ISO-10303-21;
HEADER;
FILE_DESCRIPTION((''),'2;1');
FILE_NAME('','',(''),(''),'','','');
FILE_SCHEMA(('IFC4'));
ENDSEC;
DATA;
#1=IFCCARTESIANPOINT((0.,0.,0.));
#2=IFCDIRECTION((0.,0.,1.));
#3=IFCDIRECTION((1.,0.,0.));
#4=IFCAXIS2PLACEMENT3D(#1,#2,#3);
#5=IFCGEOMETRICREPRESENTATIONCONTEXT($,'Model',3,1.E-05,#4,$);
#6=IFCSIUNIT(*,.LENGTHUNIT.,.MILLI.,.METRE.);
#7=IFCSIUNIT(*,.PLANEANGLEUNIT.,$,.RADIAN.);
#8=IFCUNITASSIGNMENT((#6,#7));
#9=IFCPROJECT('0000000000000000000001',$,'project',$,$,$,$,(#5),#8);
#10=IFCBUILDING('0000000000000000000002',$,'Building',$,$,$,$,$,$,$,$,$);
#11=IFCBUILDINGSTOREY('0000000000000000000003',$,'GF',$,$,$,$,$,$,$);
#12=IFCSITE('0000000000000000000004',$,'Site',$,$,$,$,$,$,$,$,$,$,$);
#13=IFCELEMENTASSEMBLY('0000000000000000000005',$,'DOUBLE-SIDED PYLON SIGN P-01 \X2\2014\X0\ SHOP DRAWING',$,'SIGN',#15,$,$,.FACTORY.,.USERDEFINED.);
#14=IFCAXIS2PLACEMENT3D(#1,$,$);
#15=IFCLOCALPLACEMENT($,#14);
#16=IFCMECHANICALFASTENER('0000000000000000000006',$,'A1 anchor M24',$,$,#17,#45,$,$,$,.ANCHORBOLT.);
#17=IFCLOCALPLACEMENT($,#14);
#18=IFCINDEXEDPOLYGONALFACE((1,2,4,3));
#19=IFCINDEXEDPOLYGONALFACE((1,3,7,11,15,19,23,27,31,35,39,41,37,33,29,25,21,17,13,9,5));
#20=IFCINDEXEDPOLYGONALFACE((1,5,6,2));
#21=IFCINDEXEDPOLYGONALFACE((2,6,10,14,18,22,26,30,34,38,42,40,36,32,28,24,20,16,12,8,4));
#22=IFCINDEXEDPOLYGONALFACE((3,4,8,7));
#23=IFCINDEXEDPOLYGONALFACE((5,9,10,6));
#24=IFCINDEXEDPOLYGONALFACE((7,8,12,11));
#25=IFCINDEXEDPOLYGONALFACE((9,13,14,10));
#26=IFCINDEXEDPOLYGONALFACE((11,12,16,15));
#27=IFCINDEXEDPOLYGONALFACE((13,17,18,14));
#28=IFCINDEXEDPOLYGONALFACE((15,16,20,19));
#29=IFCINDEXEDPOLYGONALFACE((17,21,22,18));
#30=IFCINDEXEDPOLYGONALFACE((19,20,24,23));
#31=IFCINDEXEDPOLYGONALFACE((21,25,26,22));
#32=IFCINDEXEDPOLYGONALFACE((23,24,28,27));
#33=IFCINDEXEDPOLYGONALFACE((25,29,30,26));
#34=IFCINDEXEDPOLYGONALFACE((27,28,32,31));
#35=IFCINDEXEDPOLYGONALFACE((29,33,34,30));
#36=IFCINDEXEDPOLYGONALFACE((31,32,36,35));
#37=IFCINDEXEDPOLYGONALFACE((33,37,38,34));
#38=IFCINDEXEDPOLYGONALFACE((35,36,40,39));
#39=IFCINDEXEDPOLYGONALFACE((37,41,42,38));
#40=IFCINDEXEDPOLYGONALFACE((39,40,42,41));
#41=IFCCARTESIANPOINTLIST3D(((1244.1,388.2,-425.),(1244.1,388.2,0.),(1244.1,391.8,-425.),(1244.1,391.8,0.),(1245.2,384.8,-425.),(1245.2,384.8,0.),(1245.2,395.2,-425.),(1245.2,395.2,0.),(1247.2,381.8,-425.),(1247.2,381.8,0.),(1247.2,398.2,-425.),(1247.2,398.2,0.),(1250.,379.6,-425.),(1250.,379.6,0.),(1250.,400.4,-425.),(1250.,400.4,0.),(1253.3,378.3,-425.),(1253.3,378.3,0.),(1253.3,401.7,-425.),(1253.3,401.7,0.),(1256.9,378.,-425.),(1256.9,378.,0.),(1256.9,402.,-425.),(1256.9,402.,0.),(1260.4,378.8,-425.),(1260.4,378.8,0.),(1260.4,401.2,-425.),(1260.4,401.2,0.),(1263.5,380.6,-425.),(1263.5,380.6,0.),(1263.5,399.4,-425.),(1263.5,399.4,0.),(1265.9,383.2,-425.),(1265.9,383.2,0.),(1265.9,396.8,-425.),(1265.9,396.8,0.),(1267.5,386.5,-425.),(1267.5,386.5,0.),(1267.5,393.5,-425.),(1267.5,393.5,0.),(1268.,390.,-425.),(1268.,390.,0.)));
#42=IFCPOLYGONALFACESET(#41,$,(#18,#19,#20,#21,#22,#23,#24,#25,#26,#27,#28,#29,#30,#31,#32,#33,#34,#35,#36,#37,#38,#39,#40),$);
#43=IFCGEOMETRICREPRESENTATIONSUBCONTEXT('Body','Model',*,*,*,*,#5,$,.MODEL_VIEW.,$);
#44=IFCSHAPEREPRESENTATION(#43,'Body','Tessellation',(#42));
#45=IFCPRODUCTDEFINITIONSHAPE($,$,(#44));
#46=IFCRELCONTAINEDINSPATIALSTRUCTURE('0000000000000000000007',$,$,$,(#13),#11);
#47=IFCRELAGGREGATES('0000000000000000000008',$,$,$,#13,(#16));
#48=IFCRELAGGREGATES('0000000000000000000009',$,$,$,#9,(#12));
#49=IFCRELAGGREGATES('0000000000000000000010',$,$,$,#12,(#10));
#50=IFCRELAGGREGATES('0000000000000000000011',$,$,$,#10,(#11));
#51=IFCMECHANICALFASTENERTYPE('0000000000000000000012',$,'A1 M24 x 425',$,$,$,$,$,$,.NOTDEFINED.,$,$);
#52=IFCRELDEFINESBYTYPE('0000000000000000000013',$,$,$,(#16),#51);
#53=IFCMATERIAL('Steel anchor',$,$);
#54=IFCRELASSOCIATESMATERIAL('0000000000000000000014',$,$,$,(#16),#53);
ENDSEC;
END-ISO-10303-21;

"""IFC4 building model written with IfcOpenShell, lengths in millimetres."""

from ifc_helpers import new_model, si_unit, frame, origin, origin_with_axes, place, context, subcontext, project, spatial, circle, extrude, material, type_object, element, aggregate, save


model = new_model("IFC4")

# Units and contexts
model_context = context("Model", 3, precision=1e-05, world=origin_with_axes())
body_context = subcontext(model_context, "Body", "Model", "MODEL_VIEW")
ifc_project = project(units=[si_unit("LENGTHUNIT", "METRE", prefix="MILLI"), si_unit("PLANEANGLEUNIT", "RADIAN")], contexts=[model_context])

# Site, building, storey
site = spatial("IfcSite", under=ifc_project, Name="Site")
building = spatial("IfcBuilding", under=site, Name="Building")
storey = spatial("IfcBuildingStorey", under=building, Name="GF")

# Element assembly, mechanical fastener
assembly_placement = place(None, origin_with_axes())
assembly = element("IfcElementAssembly", 1, at=assembly_placement, inside=storey, Name="DOUBLE-SIDED PYLON SIGN P-01 — SHOP DRAWING", ObjectType="SIGN", AssemblyPlace="FACTORY", PredefinedType="USERDEFINED")
ifc_material_1 = material(Name="Steel anchor")
mechanical_fastener_type = type_object("IfcMechanicalFastenerType", Name="A1 M24 x 425", PredefinedType="NOTDEFINED")
mechanical_fastener_1_placement = place(assembly_placement, frame((1256.0, 390.0, -425.0), z_axis=(0.0, 0.0, 1.0), x_axis=(1.0, 0.0, 0.0)))
mechanical_fastener_1 = element("IfcMechanicalFastener", 2, at=mechanical_fastener_1_placement, type_object=mechanical_fastener_type, material=ifc_material_1, Name="A1 anchor M24", PredefinedType="ANCHORBOLT", context=body_context, shape_type="SweptSolid", body=[
    extrude(circle(Radius=12.0), origin(), (0.0, 0.0, 1.0), 425.0),
])
aggregate(assembly, [mechanical_fastener_1])

save(model, "model.ifc")
